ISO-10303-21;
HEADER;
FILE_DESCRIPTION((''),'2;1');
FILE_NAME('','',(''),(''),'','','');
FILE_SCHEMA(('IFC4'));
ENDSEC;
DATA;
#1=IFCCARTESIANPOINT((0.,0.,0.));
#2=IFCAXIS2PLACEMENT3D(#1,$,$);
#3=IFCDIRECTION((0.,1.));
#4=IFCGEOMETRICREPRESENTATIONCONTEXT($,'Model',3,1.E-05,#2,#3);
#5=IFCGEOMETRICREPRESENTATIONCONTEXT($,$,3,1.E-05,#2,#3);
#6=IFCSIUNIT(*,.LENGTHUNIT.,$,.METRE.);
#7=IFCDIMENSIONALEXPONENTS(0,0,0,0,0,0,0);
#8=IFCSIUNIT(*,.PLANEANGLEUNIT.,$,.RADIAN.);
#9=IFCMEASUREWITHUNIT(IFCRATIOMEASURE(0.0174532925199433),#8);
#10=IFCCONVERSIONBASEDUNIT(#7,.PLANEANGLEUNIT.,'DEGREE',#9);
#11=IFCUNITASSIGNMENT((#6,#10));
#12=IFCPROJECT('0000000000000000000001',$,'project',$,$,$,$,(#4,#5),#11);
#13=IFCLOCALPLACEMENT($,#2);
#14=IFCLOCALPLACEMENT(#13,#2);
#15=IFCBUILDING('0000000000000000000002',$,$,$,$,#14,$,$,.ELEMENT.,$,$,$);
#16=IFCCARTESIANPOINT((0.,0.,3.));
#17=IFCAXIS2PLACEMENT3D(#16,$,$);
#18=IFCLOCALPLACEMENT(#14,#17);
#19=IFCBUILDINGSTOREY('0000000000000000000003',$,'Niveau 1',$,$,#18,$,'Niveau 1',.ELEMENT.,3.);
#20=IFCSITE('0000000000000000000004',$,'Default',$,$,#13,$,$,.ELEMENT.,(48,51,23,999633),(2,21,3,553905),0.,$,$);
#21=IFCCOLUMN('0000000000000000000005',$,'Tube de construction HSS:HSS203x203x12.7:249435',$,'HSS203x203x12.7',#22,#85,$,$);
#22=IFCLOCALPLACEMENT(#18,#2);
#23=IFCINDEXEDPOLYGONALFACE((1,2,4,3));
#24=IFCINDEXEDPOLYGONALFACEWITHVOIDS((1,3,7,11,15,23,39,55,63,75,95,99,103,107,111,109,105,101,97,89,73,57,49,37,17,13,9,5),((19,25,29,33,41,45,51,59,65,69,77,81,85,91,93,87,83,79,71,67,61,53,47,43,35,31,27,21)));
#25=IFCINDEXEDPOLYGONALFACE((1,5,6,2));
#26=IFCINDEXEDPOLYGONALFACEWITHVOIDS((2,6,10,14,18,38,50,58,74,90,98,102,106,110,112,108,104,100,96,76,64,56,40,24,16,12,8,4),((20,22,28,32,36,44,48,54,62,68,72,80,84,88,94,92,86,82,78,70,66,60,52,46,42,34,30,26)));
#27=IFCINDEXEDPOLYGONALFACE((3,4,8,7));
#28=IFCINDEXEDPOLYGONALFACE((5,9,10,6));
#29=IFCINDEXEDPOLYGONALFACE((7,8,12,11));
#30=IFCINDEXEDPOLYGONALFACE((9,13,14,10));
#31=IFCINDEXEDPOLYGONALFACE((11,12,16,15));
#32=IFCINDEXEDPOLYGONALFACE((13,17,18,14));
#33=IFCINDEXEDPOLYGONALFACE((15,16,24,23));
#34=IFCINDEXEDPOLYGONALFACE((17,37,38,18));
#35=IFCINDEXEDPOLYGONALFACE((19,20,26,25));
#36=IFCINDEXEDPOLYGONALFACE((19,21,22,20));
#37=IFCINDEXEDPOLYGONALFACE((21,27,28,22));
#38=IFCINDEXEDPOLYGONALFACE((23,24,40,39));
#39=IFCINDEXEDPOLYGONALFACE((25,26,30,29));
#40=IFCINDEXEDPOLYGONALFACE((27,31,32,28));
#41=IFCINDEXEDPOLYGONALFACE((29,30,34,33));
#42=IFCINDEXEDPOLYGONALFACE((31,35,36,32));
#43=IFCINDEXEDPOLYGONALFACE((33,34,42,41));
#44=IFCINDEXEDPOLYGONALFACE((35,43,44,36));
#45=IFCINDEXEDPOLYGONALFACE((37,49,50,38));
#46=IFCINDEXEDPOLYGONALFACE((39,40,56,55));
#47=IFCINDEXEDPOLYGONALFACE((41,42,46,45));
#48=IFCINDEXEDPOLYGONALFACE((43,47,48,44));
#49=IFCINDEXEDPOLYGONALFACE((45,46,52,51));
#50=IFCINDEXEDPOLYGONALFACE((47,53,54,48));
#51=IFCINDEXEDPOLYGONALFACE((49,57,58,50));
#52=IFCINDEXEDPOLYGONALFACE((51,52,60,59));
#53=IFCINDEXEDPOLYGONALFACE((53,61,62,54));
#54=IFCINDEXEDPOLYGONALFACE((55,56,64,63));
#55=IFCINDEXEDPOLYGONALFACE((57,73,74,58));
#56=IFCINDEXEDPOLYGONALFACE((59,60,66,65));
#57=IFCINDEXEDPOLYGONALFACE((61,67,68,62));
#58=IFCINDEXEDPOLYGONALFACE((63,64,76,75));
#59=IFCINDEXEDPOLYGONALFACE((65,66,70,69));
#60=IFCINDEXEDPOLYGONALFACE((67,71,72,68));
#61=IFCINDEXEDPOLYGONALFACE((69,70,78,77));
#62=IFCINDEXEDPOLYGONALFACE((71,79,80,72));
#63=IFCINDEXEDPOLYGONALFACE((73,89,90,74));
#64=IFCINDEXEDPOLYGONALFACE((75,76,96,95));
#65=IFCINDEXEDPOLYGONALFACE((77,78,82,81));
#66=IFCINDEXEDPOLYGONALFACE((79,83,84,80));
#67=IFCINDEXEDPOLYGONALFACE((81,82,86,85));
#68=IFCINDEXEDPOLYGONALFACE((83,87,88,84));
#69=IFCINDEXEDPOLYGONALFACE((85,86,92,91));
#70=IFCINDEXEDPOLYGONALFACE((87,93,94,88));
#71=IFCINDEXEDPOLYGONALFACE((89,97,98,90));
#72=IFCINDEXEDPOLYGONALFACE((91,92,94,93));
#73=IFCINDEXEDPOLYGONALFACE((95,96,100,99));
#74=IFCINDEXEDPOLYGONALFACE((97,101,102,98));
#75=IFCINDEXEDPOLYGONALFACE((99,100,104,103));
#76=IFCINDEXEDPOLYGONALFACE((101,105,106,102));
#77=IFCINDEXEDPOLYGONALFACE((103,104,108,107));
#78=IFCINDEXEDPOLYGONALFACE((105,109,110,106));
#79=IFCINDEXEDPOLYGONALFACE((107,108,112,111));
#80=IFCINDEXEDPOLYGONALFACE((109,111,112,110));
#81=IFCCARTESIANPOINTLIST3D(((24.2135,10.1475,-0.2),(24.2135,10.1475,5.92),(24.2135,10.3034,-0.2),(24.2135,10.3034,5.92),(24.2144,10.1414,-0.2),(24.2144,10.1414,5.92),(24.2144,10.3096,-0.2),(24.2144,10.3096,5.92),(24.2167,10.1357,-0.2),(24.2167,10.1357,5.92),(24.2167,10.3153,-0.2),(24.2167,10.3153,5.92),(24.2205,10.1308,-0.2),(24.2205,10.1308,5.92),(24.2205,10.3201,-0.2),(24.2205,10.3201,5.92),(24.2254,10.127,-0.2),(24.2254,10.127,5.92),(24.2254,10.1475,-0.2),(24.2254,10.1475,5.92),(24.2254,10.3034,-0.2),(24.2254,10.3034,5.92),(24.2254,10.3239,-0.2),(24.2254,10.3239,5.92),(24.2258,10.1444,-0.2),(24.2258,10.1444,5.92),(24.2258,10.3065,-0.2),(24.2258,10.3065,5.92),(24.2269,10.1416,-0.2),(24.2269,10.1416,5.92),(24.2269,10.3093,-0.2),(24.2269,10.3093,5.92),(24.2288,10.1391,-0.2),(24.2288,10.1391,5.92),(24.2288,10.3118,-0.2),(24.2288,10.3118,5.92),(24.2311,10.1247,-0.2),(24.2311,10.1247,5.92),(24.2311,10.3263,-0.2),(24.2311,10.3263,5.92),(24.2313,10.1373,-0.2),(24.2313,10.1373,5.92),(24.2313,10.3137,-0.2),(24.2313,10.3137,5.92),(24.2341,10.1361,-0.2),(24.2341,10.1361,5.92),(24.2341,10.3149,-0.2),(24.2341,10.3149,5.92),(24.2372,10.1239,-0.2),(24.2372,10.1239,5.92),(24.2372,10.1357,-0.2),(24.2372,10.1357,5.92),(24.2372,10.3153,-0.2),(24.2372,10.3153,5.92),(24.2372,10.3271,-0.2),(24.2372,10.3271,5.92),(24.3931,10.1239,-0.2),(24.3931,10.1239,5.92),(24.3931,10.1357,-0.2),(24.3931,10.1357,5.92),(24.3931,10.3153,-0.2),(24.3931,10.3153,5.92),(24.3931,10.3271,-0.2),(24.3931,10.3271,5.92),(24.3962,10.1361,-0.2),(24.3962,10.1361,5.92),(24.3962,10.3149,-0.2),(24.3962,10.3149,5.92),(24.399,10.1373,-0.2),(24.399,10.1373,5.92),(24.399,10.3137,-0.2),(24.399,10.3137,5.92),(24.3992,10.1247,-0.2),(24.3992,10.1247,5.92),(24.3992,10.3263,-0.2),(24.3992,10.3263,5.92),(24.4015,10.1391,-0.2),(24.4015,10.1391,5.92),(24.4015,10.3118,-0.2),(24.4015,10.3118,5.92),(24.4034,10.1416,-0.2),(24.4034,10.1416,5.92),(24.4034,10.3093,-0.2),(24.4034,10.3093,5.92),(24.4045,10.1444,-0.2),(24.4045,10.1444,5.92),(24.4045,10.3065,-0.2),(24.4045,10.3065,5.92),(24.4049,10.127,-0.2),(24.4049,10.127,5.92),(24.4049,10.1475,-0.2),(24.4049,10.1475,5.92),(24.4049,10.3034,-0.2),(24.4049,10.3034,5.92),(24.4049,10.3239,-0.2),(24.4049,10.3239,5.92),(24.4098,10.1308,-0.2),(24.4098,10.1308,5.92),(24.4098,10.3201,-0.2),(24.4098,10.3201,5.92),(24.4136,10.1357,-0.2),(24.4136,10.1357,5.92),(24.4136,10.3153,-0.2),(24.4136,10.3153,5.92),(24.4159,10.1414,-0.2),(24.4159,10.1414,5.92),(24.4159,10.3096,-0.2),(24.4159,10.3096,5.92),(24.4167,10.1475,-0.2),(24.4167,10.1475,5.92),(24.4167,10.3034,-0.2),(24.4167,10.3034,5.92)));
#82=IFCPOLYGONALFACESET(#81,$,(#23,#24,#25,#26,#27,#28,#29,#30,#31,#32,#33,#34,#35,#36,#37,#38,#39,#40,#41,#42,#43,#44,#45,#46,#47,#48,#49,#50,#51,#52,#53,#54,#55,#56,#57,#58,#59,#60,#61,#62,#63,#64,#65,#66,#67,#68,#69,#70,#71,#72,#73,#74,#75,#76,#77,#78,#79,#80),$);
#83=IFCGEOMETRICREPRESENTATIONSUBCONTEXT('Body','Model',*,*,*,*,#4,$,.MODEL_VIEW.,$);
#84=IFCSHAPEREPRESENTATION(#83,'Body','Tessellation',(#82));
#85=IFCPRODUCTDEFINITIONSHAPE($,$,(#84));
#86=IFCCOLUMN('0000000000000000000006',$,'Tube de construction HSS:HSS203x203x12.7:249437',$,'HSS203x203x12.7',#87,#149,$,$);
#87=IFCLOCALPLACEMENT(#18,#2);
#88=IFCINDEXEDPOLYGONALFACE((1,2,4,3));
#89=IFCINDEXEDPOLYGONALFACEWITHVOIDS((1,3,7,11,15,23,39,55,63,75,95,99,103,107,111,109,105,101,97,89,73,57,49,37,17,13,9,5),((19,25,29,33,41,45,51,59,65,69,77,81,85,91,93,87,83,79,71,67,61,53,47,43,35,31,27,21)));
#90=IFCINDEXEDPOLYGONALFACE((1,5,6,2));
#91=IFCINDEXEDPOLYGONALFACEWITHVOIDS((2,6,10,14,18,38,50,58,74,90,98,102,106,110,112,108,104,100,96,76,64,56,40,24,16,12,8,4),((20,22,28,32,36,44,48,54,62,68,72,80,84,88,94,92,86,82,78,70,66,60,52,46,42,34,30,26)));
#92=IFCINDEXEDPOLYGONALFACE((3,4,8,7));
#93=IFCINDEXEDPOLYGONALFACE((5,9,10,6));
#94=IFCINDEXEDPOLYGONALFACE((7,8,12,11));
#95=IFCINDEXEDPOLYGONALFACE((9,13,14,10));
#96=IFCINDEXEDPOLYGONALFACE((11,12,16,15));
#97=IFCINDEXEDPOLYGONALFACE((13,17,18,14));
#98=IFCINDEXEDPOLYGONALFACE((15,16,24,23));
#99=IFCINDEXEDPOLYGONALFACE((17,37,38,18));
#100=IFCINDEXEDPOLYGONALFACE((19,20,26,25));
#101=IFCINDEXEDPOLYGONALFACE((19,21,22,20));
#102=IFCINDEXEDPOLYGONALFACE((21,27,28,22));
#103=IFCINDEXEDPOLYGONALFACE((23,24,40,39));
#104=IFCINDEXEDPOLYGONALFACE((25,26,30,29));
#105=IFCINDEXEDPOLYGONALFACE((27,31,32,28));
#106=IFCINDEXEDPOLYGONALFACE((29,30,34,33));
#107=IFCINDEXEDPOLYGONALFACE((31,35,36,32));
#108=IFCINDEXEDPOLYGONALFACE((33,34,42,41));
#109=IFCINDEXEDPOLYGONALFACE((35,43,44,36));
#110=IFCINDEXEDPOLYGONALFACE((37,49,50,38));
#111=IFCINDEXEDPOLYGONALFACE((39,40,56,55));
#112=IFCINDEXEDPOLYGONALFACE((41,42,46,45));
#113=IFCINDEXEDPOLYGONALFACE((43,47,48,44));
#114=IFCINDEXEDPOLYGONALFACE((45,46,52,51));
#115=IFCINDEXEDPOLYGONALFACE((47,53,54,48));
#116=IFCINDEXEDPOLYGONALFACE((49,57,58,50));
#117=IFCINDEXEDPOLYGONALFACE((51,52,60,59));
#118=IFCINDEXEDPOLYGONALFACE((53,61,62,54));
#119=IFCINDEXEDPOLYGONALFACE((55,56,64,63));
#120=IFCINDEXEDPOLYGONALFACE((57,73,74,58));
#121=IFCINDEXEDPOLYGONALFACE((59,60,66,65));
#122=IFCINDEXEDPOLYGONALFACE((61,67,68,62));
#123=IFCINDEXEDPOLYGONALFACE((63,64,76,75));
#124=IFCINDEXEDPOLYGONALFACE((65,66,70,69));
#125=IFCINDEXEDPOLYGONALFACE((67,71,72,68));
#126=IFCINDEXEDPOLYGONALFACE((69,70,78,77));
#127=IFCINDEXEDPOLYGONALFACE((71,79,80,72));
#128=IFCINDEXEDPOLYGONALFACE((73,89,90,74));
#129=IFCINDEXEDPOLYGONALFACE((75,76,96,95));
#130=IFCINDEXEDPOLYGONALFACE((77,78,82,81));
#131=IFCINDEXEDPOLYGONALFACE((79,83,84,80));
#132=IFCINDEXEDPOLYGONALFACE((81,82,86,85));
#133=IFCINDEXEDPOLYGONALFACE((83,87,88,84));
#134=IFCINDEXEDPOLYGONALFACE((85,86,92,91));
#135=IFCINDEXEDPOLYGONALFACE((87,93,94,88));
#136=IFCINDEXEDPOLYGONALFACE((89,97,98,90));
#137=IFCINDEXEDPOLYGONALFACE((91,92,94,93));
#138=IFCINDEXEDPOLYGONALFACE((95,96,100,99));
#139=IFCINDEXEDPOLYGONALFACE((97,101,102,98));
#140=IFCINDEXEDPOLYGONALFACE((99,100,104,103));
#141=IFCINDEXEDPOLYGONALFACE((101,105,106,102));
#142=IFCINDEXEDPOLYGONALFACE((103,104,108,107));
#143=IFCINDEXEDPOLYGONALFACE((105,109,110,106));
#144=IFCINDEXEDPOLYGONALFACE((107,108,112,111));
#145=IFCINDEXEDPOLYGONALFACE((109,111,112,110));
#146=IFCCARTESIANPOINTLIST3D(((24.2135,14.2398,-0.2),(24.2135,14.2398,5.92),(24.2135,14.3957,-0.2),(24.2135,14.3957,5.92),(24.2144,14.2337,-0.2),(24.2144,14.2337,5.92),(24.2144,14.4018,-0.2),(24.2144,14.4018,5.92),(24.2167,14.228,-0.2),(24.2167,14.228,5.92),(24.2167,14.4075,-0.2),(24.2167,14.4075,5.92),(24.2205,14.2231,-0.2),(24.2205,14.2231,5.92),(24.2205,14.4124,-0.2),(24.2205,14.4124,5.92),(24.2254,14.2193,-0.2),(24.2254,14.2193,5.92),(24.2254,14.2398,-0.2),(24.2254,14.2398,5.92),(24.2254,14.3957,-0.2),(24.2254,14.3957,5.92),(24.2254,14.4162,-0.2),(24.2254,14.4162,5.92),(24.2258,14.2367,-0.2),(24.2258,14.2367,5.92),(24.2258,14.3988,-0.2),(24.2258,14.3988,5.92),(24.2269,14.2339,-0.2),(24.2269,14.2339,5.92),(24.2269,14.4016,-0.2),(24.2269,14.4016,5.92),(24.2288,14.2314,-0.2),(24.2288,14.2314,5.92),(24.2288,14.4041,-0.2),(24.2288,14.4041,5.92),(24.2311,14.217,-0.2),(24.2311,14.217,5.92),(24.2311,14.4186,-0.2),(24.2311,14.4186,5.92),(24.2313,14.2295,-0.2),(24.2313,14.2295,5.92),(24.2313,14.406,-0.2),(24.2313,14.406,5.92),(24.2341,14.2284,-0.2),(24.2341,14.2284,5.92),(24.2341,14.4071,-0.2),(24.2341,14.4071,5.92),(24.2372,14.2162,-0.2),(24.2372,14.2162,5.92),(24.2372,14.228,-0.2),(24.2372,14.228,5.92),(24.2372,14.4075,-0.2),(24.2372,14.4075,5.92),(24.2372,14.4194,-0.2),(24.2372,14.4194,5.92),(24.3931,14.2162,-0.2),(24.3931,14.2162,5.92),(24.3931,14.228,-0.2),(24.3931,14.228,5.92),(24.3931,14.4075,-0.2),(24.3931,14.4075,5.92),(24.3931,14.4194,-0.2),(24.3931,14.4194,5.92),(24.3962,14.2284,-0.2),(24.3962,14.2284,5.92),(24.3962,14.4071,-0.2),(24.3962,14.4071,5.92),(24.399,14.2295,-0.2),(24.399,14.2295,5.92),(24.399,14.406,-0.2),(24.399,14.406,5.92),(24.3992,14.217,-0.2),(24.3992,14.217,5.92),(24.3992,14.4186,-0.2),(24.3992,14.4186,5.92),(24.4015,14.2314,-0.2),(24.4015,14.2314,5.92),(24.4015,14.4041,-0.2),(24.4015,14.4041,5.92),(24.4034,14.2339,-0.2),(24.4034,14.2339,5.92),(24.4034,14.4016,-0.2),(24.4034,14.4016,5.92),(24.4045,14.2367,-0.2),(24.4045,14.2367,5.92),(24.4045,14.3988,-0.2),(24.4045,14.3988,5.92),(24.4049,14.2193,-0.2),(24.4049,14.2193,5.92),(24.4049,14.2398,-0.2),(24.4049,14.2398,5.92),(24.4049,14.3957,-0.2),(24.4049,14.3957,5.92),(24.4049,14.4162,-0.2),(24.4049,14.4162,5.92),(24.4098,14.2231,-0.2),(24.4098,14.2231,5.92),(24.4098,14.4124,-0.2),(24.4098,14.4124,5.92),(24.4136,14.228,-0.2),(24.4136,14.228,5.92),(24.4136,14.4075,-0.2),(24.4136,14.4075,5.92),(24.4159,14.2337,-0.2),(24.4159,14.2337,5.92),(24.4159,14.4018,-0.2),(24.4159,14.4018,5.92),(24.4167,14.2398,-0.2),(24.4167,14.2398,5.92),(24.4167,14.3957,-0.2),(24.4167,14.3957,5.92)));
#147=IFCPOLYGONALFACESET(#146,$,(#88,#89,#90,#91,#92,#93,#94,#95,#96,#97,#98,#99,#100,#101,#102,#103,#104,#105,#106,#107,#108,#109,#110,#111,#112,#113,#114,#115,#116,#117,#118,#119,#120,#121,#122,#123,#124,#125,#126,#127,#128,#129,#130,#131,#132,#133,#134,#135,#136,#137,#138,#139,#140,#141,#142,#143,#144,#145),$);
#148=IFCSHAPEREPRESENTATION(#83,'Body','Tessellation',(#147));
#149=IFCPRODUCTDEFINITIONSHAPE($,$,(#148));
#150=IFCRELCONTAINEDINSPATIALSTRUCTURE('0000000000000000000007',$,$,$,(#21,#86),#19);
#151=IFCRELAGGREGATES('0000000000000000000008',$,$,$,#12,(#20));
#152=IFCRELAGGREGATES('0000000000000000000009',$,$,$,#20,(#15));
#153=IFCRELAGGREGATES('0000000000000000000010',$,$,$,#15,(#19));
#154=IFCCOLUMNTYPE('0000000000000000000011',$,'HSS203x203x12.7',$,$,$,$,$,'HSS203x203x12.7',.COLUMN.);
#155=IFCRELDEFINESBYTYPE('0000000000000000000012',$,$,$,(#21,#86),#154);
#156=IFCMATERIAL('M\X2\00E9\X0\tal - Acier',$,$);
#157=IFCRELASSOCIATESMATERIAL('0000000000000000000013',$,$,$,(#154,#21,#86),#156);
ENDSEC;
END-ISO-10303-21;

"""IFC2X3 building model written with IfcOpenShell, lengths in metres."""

from ifc_helpers import new_model, entity, si_unit, converted_unit, direction, frame, frame_2d, origin, place, context, subcontext, project, spatial, polyline, circle_curve, parameter, trimmed, segment, composite_curve, outline, extrude, source, transform, mapped, material, type_object, type_shapes, element, save


model = new_model("IFC2X3")

# Units and contexts
model_context = context("Model", 3, precision=1e-05, world=origin(), true_north=direction((0.0, 1.0)))
context_of_model = context(None, 3, precision=1e-05, world=origin(), true_north=direction((0.0, 1.0)))
body_context = subcontext(model_context, "Body", "Model", "MODEL_VIEW")
ifc_project = project(units=[si_unit("LENGTHUNIT", "METRE"), converted_unit("PLANEANGLEUNIT", "DEGREE", entity("IfcRatioMeasure", 0.0174532925199433), si_unit("PLANEANGLEUNIT", "RADIAN"), dimensions=[0, 0, 0, 0, 0, 0, 0])], contexts=[model_context, context_of_model])

# Site, building, storey
site_placement = place(None, origin())
site = spatial("IfcSite", under=ifc_project, at=site_placement, Name="Default", CompositionType="ELEMENT", RefLatitude=(48, 51, 23, 999633), RefLongitude=(2, 21, 3, 553905), RefElevation=0.0)
building_placement = place(site_placement, origin())
building = spatial("IfcBuilding", under=site, at=building_placement, CompositionType="ELEMENT")
storey_placement = place(building_placement, frame((0.0, 0.0, 3.0)))
storey = spatial("IfcBuildingStorey", under=building, at=storey_placement, Name="Niveau 1", LongName="Niveau 1", CompositionType="ELEMENT", Elevation=3.0)

# Columns
ifc_material_1 = material(Name="Métal - Acier")
column_type = type_object("IfcColumnType", Name="HSS203x203x12.7", ElementType="HSS203x203x12.7", PredefinedType="COLUMN", material=ifc_material_1)
shared_shape = source(origin(), body_context, "Body", "SweptSolid", [
    extrude(outline(composite_curve([segment(polyline([(-0.078, -0.1016), (0.078, -0.1016)]), True, "CONTINUOUS"), segment(trimmed(circle_curve(frame_2d((0.078, -0.078), x_axis=(-1.0, 0.0)), 0.0236), [parameter(90.0)], [parameter(180.0)], True, "PARAMETER"), True, "CONTINUOUS"), segment(polyline([(0.1016, -0.078), (0.1016, 0.078)]), True, "CONTINUOUS"), segment(trimmed(circle_curve(frame_2d((0.078, 0.078), x_axis=(-1.0, 0.0)), 0.0236), [parameter(180.0)], [parameter(270.0)], True, "PARAMETER"), True, "CONTINUOUS"), segment(polyline([(0.078, 0.1016), (-0.078, 0.1016)]), True, "CONTINUOUS"), segment(trimmed(circle_curve(frame_2d((-0.078, 0.078), x_axis=(-1.0, 0.0)), 0.0236), [parameter(270.0)], [parameter(360.0)], True, "PARAMETER"), True, "CONTINUOUS"), segment(polyline([(-0.1016, 0.078), (-0.1016, -0.078)]), True, "CONTINUOUS"), segment(trimmed(circle_curve(frame_2d((-0.078, -0.078), x_axis=(-1.0, 0.0)), 0.0236), [parameter(360.0)], [parameter(90.0)], True, "PARAMETER"), True, "CONTINUOUS")], self_intersect=False), holes=[composite_curve([segment(trimmed(circle_curve(frame_2d((-0.078, -0.078), x_axis=(-1.0, 0.0)), 0.0118), [parameter(0.0)], [parameter(90.0)], True, "PARAMETER"), False, "CONTINUOUS"), segment(polyline([(-0.0898, -0.078), (-0.0898, 0.078)]), True, "CONTINUOUS"), segment(trimmed(circle_curve(frame_2d((-0.078, 0.078), x_axis=(-1.0, 0.0)), 0.0118), [parameter(270.0)], [parameter(360.0)], True, "PARAMETER"), False, "CONTINUOUS"), segment(polyline([(-0.078, 0.0898), (0.078, 0.0898)]), True, "CONTINUOUS"), segment(trimmed(circle_curve(frame_2d((0.078, 0.078), x_axis=(-1.0, 0.0)), 0.0118), [parameter(180.0)], [parameter(270.0)], True, "PARAMETER"), False, "CONTINUOUS"), segment(polyline([(0.0898, 0.078), (0.0898, -0.078)]), True, "CONTINUOUS"), segment(trimmed(circle_curve(frame_2d((0.078, -0.078), x_axis=(-1.0, 0.0)), 0.0118), [parameter(90.0)], [parameter(180.0)], True, "PARAMETER"), False, "CONTINUOUS"), segment(polyline([(0.078, -0.0898), (-0.078, -0.0898)]), True, "CONTINUOUS")], self_intersect=False)]), frame((0.0, 0.0, 2.8), z_axis=(0.0, 0.0, 1.0), x_axis=(-1.0, 0.0, 0.0)), (0.0, 0.0, 1.0), 6.12),
])
type_shapes(column_type, [shared_shape])
for number, where, name in (
    (1, (24.3151, 10.2255, -3.0), "Tube de construction HSS:HSS203x203x12.7:249435"),
    (2, (24.3151, 14.3178, -3.0), "Tube de construction HSS:HSS203x203x12.7:249437"),
):
    element("IfcColumn", number, at=place(storey_placement, frame(where)), inside=storey, type_object=column_type, material=ifc_material_1, Name=name, ObjectType="HSS203x203x12.7", context=body_context, shape_type="MappedRepresentation", body=[
        mapped(shared_shape, transform((0.0, 0.0, 0.0), scale=1.0)),
    ])

save(model, "model.ifc")
